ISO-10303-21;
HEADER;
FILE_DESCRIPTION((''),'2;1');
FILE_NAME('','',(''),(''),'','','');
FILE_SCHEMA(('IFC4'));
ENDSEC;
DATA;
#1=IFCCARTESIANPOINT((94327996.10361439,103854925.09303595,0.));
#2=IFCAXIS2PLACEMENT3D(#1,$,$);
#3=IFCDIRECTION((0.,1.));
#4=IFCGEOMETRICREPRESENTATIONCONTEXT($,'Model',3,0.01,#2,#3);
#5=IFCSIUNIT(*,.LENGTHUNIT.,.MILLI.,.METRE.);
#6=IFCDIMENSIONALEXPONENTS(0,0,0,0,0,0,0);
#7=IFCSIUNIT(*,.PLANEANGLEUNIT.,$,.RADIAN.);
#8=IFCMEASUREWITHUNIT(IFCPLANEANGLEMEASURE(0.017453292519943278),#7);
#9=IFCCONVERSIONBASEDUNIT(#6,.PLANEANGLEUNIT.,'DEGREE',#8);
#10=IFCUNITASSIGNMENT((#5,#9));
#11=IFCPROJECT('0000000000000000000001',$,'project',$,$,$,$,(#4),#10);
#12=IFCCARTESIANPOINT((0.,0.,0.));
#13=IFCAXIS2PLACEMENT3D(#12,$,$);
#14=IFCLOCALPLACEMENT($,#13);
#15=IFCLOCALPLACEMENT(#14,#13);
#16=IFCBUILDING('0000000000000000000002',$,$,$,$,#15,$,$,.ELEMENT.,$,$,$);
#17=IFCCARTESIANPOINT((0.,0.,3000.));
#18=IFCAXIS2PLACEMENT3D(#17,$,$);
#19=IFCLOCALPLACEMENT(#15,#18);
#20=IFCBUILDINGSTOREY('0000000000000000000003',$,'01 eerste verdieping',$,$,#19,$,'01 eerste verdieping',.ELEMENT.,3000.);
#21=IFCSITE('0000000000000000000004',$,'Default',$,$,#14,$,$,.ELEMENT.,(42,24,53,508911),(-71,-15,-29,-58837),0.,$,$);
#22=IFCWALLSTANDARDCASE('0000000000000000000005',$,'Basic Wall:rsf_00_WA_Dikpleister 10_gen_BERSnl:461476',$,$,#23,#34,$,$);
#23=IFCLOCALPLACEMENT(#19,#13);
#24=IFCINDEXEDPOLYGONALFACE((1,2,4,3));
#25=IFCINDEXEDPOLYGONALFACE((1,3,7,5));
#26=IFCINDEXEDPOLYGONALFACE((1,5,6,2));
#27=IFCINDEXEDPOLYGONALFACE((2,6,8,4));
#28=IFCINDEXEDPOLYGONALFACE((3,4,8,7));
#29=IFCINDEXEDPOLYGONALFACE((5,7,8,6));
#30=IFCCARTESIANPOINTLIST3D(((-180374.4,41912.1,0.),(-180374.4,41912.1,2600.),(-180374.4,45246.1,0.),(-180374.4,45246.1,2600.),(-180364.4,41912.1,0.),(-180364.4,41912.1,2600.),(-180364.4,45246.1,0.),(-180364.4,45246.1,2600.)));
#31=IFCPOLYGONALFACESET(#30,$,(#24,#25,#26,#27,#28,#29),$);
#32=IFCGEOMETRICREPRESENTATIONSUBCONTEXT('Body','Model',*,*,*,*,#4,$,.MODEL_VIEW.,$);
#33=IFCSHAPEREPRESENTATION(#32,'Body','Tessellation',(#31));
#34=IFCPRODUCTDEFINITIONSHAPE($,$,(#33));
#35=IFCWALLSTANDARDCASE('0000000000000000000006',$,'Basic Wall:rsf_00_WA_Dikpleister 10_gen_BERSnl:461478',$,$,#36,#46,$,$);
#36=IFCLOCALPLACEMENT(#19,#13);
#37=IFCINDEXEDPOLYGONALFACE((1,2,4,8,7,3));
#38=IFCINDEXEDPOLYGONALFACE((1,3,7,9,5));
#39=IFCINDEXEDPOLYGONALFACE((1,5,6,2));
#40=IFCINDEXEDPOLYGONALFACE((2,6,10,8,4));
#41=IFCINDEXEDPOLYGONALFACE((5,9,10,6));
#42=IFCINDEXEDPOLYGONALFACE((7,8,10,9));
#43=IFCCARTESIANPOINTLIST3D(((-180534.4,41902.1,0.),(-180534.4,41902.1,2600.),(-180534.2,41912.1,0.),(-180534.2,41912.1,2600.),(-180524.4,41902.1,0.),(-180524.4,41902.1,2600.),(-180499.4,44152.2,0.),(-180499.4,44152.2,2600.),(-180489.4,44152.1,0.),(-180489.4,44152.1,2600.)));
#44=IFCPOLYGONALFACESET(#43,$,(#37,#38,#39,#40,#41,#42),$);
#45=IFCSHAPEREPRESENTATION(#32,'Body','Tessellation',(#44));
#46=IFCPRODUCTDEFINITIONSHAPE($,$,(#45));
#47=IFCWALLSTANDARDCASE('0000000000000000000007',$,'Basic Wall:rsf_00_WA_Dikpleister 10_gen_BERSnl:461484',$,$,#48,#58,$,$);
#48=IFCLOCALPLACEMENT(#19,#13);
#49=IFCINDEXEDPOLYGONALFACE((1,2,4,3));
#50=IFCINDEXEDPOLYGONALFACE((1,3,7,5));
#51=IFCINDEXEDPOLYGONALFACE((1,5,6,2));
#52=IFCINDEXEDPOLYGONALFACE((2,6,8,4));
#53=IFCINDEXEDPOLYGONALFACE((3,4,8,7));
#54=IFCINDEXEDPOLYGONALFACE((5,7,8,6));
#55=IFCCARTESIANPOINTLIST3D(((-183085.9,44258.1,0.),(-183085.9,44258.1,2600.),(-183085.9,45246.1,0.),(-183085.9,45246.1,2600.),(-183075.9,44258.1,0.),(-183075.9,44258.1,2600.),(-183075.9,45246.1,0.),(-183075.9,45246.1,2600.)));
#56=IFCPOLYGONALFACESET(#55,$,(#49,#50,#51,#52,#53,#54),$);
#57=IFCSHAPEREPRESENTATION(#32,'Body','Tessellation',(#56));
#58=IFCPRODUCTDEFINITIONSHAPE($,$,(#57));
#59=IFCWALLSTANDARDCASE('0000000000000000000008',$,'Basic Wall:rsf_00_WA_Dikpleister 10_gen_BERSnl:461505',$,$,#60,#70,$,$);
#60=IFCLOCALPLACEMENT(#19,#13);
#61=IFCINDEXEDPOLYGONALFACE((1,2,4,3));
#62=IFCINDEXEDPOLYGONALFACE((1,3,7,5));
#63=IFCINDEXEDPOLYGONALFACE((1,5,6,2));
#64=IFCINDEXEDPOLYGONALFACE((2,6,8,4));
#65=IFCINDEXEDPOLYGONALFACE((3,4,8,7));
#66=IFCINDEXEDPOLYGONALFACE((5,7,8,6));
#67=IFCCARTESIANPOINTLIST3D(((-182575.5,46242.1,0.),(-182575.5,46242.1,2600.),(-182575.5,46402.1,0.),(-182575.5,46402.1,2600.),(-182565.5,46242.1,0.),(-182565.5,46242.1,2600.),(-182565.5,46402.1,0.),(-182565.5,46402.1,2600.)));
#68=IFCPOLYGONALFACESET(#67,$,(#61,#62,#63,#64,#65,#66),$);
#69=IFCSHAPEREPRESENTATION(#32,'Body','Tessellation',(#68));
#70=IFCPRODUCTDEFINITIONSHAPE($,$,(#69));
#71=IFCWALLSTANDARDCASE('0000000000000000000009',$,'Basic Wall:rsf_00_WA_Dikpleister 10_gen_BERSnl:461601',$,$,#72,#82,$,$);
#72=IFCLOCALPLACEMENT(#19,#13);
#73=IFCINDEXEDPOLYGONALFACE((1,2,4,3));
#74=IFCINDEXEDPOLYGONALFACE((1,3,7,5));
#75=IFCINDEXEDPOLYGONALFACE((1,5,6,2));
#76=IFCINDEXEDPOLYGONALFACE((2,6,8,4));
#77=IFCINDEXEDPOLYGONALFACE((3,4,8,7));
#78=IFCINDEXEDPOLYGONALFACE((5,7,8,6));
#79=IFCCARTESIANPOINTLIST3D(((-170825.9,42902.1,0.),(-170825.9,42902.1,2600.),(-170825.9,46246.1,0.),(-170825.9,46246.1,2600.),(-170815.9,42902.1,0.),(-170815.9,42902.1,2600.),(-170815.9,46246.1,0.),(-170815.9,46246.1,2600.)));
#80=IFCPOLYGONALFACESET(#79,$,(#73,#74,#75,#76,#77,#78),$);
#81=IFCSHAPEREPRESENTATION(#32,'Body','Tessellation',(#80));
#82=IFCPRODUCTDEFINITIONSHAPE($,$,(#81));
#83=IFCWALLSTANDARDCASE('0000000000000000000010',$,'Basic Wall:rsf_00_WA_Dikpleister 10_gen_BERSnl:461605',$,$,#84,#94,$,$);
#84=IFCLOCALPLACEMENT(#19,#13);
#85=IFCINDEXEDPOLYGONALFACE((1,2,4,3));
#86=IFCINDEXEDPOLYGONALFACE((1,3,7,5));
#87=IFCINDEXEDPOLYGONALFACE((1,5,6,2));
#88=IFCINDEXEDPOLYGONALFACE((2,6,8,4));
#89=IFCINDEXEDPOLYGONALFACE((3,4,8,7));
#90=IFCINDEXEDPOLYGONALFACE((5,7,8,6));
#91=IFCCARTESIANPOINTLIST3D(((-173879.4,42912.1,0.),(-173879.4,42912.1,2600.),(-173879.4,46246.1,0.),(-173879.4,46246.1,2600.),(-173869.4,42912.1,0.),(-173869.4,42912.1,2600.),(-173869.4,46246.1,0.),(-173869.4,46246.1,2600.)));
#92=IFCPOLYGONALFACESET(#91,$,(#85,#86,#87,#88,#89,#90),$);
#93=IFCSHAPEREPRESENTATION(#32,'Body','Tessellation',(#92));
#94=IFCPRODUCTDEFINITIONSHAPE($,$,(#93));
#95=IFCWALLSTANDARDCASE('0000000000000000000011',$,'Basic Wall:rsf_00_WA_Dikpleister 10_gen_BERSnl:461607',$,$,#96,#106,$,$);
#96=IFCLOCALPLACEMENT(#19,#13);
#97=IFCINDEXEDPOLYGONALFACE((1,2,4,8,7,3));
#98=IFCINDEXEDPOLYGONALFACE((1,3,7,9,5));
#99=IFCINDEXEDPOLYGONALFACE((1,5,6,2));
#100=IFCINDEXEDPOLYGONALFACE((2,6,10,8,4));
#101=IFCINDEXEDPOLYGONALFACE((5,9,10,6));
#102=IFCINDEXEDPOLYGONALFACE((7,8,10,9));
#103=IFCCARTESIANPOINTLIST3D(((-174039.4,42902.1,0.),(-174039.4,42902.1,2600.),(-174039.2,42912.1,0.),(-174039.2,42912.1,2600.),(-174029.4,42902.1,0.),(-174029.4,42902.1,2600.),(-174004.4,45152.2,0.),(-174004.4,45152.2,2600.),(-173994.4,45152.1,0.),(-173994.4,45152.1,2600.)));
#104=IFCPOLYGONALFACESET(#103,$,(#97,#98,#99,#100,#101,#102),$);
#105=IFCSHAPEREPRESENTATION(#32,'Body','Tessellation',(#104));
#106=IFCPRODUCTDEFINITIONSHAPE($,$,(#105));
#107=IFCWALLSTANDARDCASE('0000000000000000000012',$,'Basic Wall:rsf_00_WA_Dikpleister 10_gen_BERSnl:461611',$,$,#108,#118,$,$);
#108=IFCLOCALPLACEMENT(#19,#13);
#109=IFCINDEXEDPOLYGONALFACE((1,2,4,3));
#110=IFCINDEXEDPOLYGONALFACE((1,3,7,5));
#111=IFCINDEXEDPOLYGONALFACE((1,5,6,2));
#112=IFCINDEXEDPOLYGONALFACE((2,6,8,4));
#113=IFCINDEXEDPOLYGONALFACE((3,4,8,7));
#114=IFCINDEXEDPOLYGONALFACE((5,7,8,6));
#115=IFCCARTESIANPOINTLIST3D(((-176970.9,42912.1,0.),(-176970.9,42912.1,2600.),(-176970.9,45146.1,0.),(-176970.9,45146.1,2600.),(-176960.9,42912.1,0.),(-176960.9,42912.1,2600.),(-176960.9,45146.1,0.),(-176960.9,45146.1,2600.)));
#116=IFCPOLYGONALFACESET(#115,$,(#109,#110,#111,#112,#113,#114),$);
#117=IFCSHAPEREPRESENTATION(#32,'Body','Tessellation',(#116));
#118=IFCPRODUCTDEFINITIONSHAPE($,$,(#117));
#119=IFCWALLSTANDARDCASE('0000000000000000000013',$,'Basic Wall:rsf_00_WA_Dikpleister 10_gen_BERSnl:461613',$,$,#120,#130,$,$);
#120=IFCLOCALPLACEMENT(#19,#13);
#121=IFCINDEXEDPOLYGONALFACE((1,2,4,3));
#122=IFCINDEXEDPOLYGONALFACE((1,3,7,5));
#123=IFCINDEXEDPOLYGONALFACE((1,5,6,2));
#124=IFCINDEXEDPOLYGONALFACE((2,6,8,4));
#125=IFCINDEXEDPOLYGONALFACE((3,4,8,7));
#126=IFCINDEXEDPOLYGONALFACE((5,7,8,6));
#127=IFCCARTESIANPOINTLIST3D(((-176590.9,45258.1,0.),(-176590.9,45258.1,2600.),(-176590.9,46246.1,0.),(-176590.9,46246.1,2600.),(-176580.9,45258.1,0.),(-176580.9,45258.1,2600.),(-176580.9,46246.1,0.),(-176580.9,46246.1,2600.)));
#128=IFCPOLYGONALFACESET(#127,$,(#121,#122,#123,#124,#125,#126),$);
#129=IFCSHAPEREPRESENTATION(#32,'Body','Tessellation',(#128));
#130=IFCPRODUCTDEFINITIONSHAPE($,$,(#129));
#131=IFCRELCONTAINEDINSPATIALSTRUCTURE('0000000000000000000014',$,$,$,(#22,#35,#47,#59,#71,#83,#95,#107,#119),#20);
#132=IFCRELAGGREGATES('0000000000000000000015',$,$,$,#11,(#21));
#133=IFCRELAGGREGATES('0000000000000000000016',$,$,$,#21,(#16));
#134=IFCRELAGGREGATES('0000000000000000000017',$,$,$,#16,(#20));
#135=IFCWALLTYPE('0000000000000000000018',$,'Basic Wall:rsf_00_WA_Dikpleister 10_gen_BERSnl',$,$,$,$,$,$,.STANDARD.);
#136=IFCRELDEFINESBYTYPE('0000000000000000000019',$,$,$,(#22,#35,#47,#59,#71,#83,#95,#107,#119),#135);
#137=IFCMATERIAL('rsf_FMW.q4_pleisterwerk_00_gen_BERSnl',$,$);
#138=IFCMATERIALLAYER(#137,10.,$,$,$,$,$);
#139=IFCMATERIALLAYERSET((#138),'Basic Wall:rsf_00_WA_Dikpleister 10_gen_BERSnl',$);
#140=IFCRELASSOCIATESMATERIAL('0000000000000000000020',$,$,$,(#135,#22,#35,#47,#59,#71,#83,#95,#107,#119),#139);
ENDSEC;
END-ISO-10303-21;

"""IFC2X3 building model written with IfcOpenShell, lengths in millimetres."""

from ifc_helpers import new_model, entity, si_unit, converted_unit, direction, frame, frame_2d, origin, place, context, subcontext, project, spatial, polyline, rectangle, outline, extrude, material, layer, layer_set, layer_usage, type_object, element, save


model = new_model("IFC2X3")

# Units and contexts
model_context = context("Model", 3, precision=0.01, world=frame((94327996.10361439, 103854925.09303595, 0.0)), true_north=direction((0.0, 1.0)))
body_context = subcontext(model_context, "Body", "Model", "MODEL_VIEW")
ifc_project = project(units=[si_unit("LENGTHUNIT", "METRE", prefix="MILLI"), converted_unit("PLANEANGLEUNIT", "DEGREE", entity("IfcPlaneAngleMeasure", 0.017453292519943278), si_unit("PLANEANGLEUNIT", "RADIAN"), dimensions=[0, 0, 0, 0, 0, 0, 0])], contexts=[model_context])

# Site, building, storey
site_placement = place(None, origin())
site = spatial("IfcSite", under=ifc_project, at=site_placement, Name="Default", CompositionType="ELEMENT", RefLatitude=(42, 24, 53, 508911), RefLongitude=(-71, -15, -29, -58837), RefElevation=0.0)
building_placement = place(site_placement, origin())
building = spatial("IfcBuilding", under=site, at=building_placement, CompositionType="ELEMENT")
storey_placement = place(building_placement, frame((0.0, 0.0, 3000.0)))
storey = spatial("IfcBuildingStorey", under=building, at=storey_placement, Name="01 eerste verdieping", LongName="01 eerste verdieping", CompositionType="ELEMENT", Elevation=3000.0)

# Shared definitions
ifc_material_1 = material(Name="rsf_FMW.q4_pleisterwerk_00_gen_BERSnl")

# Walls
ifc_layer_1 = layer(ifc_material_1, 10.0)
ifc_layer_set_1 = layer_set([ifc_layer_1], Name="Basic Wall:rsf_00_WA_Dikpleister 10_gen_BERSnl")
wall_type_1 = type_object("IfcWallType", Name="Basic Wall:rsf_00_WA_Dikpleister 10_gen_BERSnl", PredefinedType="STANDARD", material=ifc_layer_set_1)
ifc_layer_usage_1 = layer_usage(ifc_layer_set_1, "AXIS2", "POSITIVE", -5.0)
wall_1_placement = place(storey_placement, frame((-180369.4, 41912.1, 0.0), z_axis=(0.0, 0.0, 1.0), x_axis=(0.0, 1.0, 0.0)))
element("IfcWallStandardCase", 1, at=wall_1_placement, inside=storey, type_object=wall_type_1, material=ifc_layer_usage_1, Name="Basic Wall:rsf_00_WA_Dikpleister 10_gen_BERSnl:461476", context=body_context, shape_type="SweptSolid", body=[
    extrude(rectangle(XDim=3334.0, YDim=10.0, at=frame_2d((1667.0, 0.0), x_axis=(-1.0, 0.0))), origin(), (0.0, 0.0, 1.0), 2600.0),
])
ifc_layer_usage_2 = layer_usage(ifc_layer_set_1, "AXIS2", "POSITIVE", -5.0)
wall_2_placement = place(storey_placement, frame((-180494.4, 44152.1, 0.0), z_axis=(0.0, 0.0, 1.0), x_axis=(-0.015554, -0.999879, 0.0)))
element("IfcWallStandardCase", 2, at=wall_2_placement, inside=storey, type_object=wall_type_1, material=ifc_layer_usage_2, Name="Basic Wall:rsf_00_WA_Dikpleister 10_gen_BERSnl:461478", context=body_context, shape_type="SweptSolid", body=[
    extrude(outline(polyline([(0.0, 5.0), (0.0, -5.0), (2240.4, -5.0), (2250.4, -5.0), (2250.3, 5.0), (0.0, 5.0)])), origin(), (0.0, 0.0, 1.0), 2600.0),
])
ifc_layer_usage_3 = layer_usage(ifc_layer_set_1, "AXIS2", "POSITIVE", -5.0)
wall_3_placement = place(storey_placement, frame((-183080.9, 44258.1, 0.0), z_axis=(0.0, 0.0, 1.0), x_axis=(0.0, 1.0, 0.0)))
element("IfcWallStandardCase", 3, at=wall_3_placement, inside=storey, type_object=wall_type_1, material=ifc_layer_usage_3, Name="Basic Wall:rsf_00_WA_Dikpleister 10_gen_BERSnl:461484", context=body_context, shape_type="SweptSolid", body=[
    extrude(rectangle(XDim=988.0, YDim=10.0, at=frame_2d((494.0, 0.0), x_axis=(-1.0, 0.0))), origin(), (0.0, 0.0, 1.0), 2600.0),
])

# Walls
ifc_layer_usage_4 = layer_usage(ifc_layer_set_1, "AXIS2", "POSITIVE", -5.0)
wall_4_placement = place(storey_placement, frame((-182570.5, 46242.1, 0.0), z_axis=(0.0, 0.0, 1.0), x_axis=(0.0, 1.0, 0.0)))
element("IfcWallStandardCase", 4, at=wall_4_placement, inside=storey, type_object=wall_type_1, material=ifc_layer_usage_4, Name="Basic Wall:rsf_00_WA_Dikpleister 10_gen_BERSnl:461505", context=body_context, shape_type="SweptSolid", body=[
    extrude(rectangle(XDim=160.0, YDim=10.0, at=frame_2d((80.0, 0.0), x_axis=(-1.0, 0.0))), origin(), (0.0, 0.0, 1.0), 2600.0),
])
ifc_layer_usage_5 = layer_usage(ifc_layer_set_1, "AXIS2", "POSITIVE", -5.0)
wall_5_placement = place(storey_placement, frame((-170820.9, 46246.1, 0.0), z_axis=(0.0, 0.0, 1.0), x_axis=(0.0, -1.0, 0.0)))
element("IfcWallStandardCase", 5, at=wall_5_placement, inside=storey, type_object=wall_type_1, material=ifc_layer_usage_5, Name="Basic Wall:rsf_00_WA_Dikpleister 10_gen_BERSnl:461601", context=body_context, shape_type="SweptSolid", body=[
    extrude(rectangle(XDim=3344.0, YDim=10.0, at=frame_2d((1672.0, 0.0), x_axis=(-1.0, 0.0))), origin(), (0.0, 0.0, 1.0), 2600.0),
])
ifc_layer_usage_6 = layer_usage(ifc_layer_set_1, "AXIS2", "POSITIVE", -5.0)
wall_6_placement = place(storey_placement, frame((-173874.4, 42912.1, 0.0), z_axis=(0.0, 0.0, 1.0), x_axis=(0.0, 1.0, 0.0)))
element("IfcWallStandardCase", 6, at=wall_6_placement, inside=storey, type_object=wall_type_1, material=ifc_layer_usage_6, Name="Basic Wall:rsf_00_WA_Dikpleister 10_gen_BERSnl:461605", context=body_context, shape_type="SweptSolid", body=[
    extrude(rectangle(XDim=3334.0, YDim=10.0, at=frame_2d((1667.0, 0.0), x_axis=(-1.0, 0.0))), origin(), (0.0, 0.0, 1.0), 2600.0),
])
ifc_layer_usage_7 = layer_usage(ifc_layer_set_1, "AXIS2", "POSITIVE", -5.0)
wall_7_placement = place(storey_placement, frame((-173999.4, 45152.1, 0.0), z_axis=(0.0, 0.0, 1.0), x_axis=(-0.015554, -0.999879, 0.0)))
element("IfcWallStandardCase", 7, at=wall_7_placement, inside=storey, type_object=wall_type_1, material=ifc_layer_usage_7, Name="Basic Wall:rsf_00_WA_Dikpleister 10_gen_BERSnl:461607", context=body_context, shape_type="SweptSolid", body=[
    extrude(outline(polyline([(0.0, 5.0), (0.0, -5.0), (2240.4, -5.0), (2250.4, -5.0), (2250.3, 5.0), (0.0, 5.0)])), origin(), (0.0, 0.0, 1.0), 2600.0),
])
ifc_layer_usage_8 = layer_usage(ifc_layer_set_1, "AXIS2", "POSITIVE", -5.0)
wall_8_placement = place(storey_placement, frame((-176965.9, 42912.1, 0.0), z_axis=(0.0, 0.0, 1.0), x_axis=(0.0, 1.0, 0.0)))
element("IfcWallStandardCase", 8, at=wall_8_placement, inside=storey, type_object=wall_type_1, material=ifc_layer_usage_8, Name="Basic Wall:rsf_00_WA_Dikpleister 10_gen_BERSnl:461611", context=body_context, shape_type="SweptSolid", body=[
    extrude(rectangle(XDim=2234.0, YDim=10.0, at=frame_2d((1117.0, 0.0), x_axis=(-1.0, 0.0))), origin(), (0.0, 0.0, 1.0), 2600.0),
])
ifc_layer_usage_9 = layer_usage(ifc_layer_set_1, "AXIS2", "POSITIVE", -5.0)
wall_9_placement = place(storey_placement, frame((-176585.9, 45258.1, 0.0), z_axis=(0.0, 0.0, 1.0), x_axis=(0.0, 1.0, 0.0)))
element("IfcWallStandardCase", 9, at=wall_9_placement, inside=storey, type_object=wall_type_1, material=ifc_layer_usage_9, Name="Basic Wall:rsf_00_WA_Dikpleister 10_gen_BERSnl:461613", context=body_context, shape_type="SweptSolid", body=[
    extrude(rectangle(XDim=988.0, YDim=10.0, at=frame_2d((494.0, 0.0), x_axis=(-1.0, 0.0))), origin(), (0.0, 0.0, 1.0), 2600.0),
])

save(model, "model.ifc")
